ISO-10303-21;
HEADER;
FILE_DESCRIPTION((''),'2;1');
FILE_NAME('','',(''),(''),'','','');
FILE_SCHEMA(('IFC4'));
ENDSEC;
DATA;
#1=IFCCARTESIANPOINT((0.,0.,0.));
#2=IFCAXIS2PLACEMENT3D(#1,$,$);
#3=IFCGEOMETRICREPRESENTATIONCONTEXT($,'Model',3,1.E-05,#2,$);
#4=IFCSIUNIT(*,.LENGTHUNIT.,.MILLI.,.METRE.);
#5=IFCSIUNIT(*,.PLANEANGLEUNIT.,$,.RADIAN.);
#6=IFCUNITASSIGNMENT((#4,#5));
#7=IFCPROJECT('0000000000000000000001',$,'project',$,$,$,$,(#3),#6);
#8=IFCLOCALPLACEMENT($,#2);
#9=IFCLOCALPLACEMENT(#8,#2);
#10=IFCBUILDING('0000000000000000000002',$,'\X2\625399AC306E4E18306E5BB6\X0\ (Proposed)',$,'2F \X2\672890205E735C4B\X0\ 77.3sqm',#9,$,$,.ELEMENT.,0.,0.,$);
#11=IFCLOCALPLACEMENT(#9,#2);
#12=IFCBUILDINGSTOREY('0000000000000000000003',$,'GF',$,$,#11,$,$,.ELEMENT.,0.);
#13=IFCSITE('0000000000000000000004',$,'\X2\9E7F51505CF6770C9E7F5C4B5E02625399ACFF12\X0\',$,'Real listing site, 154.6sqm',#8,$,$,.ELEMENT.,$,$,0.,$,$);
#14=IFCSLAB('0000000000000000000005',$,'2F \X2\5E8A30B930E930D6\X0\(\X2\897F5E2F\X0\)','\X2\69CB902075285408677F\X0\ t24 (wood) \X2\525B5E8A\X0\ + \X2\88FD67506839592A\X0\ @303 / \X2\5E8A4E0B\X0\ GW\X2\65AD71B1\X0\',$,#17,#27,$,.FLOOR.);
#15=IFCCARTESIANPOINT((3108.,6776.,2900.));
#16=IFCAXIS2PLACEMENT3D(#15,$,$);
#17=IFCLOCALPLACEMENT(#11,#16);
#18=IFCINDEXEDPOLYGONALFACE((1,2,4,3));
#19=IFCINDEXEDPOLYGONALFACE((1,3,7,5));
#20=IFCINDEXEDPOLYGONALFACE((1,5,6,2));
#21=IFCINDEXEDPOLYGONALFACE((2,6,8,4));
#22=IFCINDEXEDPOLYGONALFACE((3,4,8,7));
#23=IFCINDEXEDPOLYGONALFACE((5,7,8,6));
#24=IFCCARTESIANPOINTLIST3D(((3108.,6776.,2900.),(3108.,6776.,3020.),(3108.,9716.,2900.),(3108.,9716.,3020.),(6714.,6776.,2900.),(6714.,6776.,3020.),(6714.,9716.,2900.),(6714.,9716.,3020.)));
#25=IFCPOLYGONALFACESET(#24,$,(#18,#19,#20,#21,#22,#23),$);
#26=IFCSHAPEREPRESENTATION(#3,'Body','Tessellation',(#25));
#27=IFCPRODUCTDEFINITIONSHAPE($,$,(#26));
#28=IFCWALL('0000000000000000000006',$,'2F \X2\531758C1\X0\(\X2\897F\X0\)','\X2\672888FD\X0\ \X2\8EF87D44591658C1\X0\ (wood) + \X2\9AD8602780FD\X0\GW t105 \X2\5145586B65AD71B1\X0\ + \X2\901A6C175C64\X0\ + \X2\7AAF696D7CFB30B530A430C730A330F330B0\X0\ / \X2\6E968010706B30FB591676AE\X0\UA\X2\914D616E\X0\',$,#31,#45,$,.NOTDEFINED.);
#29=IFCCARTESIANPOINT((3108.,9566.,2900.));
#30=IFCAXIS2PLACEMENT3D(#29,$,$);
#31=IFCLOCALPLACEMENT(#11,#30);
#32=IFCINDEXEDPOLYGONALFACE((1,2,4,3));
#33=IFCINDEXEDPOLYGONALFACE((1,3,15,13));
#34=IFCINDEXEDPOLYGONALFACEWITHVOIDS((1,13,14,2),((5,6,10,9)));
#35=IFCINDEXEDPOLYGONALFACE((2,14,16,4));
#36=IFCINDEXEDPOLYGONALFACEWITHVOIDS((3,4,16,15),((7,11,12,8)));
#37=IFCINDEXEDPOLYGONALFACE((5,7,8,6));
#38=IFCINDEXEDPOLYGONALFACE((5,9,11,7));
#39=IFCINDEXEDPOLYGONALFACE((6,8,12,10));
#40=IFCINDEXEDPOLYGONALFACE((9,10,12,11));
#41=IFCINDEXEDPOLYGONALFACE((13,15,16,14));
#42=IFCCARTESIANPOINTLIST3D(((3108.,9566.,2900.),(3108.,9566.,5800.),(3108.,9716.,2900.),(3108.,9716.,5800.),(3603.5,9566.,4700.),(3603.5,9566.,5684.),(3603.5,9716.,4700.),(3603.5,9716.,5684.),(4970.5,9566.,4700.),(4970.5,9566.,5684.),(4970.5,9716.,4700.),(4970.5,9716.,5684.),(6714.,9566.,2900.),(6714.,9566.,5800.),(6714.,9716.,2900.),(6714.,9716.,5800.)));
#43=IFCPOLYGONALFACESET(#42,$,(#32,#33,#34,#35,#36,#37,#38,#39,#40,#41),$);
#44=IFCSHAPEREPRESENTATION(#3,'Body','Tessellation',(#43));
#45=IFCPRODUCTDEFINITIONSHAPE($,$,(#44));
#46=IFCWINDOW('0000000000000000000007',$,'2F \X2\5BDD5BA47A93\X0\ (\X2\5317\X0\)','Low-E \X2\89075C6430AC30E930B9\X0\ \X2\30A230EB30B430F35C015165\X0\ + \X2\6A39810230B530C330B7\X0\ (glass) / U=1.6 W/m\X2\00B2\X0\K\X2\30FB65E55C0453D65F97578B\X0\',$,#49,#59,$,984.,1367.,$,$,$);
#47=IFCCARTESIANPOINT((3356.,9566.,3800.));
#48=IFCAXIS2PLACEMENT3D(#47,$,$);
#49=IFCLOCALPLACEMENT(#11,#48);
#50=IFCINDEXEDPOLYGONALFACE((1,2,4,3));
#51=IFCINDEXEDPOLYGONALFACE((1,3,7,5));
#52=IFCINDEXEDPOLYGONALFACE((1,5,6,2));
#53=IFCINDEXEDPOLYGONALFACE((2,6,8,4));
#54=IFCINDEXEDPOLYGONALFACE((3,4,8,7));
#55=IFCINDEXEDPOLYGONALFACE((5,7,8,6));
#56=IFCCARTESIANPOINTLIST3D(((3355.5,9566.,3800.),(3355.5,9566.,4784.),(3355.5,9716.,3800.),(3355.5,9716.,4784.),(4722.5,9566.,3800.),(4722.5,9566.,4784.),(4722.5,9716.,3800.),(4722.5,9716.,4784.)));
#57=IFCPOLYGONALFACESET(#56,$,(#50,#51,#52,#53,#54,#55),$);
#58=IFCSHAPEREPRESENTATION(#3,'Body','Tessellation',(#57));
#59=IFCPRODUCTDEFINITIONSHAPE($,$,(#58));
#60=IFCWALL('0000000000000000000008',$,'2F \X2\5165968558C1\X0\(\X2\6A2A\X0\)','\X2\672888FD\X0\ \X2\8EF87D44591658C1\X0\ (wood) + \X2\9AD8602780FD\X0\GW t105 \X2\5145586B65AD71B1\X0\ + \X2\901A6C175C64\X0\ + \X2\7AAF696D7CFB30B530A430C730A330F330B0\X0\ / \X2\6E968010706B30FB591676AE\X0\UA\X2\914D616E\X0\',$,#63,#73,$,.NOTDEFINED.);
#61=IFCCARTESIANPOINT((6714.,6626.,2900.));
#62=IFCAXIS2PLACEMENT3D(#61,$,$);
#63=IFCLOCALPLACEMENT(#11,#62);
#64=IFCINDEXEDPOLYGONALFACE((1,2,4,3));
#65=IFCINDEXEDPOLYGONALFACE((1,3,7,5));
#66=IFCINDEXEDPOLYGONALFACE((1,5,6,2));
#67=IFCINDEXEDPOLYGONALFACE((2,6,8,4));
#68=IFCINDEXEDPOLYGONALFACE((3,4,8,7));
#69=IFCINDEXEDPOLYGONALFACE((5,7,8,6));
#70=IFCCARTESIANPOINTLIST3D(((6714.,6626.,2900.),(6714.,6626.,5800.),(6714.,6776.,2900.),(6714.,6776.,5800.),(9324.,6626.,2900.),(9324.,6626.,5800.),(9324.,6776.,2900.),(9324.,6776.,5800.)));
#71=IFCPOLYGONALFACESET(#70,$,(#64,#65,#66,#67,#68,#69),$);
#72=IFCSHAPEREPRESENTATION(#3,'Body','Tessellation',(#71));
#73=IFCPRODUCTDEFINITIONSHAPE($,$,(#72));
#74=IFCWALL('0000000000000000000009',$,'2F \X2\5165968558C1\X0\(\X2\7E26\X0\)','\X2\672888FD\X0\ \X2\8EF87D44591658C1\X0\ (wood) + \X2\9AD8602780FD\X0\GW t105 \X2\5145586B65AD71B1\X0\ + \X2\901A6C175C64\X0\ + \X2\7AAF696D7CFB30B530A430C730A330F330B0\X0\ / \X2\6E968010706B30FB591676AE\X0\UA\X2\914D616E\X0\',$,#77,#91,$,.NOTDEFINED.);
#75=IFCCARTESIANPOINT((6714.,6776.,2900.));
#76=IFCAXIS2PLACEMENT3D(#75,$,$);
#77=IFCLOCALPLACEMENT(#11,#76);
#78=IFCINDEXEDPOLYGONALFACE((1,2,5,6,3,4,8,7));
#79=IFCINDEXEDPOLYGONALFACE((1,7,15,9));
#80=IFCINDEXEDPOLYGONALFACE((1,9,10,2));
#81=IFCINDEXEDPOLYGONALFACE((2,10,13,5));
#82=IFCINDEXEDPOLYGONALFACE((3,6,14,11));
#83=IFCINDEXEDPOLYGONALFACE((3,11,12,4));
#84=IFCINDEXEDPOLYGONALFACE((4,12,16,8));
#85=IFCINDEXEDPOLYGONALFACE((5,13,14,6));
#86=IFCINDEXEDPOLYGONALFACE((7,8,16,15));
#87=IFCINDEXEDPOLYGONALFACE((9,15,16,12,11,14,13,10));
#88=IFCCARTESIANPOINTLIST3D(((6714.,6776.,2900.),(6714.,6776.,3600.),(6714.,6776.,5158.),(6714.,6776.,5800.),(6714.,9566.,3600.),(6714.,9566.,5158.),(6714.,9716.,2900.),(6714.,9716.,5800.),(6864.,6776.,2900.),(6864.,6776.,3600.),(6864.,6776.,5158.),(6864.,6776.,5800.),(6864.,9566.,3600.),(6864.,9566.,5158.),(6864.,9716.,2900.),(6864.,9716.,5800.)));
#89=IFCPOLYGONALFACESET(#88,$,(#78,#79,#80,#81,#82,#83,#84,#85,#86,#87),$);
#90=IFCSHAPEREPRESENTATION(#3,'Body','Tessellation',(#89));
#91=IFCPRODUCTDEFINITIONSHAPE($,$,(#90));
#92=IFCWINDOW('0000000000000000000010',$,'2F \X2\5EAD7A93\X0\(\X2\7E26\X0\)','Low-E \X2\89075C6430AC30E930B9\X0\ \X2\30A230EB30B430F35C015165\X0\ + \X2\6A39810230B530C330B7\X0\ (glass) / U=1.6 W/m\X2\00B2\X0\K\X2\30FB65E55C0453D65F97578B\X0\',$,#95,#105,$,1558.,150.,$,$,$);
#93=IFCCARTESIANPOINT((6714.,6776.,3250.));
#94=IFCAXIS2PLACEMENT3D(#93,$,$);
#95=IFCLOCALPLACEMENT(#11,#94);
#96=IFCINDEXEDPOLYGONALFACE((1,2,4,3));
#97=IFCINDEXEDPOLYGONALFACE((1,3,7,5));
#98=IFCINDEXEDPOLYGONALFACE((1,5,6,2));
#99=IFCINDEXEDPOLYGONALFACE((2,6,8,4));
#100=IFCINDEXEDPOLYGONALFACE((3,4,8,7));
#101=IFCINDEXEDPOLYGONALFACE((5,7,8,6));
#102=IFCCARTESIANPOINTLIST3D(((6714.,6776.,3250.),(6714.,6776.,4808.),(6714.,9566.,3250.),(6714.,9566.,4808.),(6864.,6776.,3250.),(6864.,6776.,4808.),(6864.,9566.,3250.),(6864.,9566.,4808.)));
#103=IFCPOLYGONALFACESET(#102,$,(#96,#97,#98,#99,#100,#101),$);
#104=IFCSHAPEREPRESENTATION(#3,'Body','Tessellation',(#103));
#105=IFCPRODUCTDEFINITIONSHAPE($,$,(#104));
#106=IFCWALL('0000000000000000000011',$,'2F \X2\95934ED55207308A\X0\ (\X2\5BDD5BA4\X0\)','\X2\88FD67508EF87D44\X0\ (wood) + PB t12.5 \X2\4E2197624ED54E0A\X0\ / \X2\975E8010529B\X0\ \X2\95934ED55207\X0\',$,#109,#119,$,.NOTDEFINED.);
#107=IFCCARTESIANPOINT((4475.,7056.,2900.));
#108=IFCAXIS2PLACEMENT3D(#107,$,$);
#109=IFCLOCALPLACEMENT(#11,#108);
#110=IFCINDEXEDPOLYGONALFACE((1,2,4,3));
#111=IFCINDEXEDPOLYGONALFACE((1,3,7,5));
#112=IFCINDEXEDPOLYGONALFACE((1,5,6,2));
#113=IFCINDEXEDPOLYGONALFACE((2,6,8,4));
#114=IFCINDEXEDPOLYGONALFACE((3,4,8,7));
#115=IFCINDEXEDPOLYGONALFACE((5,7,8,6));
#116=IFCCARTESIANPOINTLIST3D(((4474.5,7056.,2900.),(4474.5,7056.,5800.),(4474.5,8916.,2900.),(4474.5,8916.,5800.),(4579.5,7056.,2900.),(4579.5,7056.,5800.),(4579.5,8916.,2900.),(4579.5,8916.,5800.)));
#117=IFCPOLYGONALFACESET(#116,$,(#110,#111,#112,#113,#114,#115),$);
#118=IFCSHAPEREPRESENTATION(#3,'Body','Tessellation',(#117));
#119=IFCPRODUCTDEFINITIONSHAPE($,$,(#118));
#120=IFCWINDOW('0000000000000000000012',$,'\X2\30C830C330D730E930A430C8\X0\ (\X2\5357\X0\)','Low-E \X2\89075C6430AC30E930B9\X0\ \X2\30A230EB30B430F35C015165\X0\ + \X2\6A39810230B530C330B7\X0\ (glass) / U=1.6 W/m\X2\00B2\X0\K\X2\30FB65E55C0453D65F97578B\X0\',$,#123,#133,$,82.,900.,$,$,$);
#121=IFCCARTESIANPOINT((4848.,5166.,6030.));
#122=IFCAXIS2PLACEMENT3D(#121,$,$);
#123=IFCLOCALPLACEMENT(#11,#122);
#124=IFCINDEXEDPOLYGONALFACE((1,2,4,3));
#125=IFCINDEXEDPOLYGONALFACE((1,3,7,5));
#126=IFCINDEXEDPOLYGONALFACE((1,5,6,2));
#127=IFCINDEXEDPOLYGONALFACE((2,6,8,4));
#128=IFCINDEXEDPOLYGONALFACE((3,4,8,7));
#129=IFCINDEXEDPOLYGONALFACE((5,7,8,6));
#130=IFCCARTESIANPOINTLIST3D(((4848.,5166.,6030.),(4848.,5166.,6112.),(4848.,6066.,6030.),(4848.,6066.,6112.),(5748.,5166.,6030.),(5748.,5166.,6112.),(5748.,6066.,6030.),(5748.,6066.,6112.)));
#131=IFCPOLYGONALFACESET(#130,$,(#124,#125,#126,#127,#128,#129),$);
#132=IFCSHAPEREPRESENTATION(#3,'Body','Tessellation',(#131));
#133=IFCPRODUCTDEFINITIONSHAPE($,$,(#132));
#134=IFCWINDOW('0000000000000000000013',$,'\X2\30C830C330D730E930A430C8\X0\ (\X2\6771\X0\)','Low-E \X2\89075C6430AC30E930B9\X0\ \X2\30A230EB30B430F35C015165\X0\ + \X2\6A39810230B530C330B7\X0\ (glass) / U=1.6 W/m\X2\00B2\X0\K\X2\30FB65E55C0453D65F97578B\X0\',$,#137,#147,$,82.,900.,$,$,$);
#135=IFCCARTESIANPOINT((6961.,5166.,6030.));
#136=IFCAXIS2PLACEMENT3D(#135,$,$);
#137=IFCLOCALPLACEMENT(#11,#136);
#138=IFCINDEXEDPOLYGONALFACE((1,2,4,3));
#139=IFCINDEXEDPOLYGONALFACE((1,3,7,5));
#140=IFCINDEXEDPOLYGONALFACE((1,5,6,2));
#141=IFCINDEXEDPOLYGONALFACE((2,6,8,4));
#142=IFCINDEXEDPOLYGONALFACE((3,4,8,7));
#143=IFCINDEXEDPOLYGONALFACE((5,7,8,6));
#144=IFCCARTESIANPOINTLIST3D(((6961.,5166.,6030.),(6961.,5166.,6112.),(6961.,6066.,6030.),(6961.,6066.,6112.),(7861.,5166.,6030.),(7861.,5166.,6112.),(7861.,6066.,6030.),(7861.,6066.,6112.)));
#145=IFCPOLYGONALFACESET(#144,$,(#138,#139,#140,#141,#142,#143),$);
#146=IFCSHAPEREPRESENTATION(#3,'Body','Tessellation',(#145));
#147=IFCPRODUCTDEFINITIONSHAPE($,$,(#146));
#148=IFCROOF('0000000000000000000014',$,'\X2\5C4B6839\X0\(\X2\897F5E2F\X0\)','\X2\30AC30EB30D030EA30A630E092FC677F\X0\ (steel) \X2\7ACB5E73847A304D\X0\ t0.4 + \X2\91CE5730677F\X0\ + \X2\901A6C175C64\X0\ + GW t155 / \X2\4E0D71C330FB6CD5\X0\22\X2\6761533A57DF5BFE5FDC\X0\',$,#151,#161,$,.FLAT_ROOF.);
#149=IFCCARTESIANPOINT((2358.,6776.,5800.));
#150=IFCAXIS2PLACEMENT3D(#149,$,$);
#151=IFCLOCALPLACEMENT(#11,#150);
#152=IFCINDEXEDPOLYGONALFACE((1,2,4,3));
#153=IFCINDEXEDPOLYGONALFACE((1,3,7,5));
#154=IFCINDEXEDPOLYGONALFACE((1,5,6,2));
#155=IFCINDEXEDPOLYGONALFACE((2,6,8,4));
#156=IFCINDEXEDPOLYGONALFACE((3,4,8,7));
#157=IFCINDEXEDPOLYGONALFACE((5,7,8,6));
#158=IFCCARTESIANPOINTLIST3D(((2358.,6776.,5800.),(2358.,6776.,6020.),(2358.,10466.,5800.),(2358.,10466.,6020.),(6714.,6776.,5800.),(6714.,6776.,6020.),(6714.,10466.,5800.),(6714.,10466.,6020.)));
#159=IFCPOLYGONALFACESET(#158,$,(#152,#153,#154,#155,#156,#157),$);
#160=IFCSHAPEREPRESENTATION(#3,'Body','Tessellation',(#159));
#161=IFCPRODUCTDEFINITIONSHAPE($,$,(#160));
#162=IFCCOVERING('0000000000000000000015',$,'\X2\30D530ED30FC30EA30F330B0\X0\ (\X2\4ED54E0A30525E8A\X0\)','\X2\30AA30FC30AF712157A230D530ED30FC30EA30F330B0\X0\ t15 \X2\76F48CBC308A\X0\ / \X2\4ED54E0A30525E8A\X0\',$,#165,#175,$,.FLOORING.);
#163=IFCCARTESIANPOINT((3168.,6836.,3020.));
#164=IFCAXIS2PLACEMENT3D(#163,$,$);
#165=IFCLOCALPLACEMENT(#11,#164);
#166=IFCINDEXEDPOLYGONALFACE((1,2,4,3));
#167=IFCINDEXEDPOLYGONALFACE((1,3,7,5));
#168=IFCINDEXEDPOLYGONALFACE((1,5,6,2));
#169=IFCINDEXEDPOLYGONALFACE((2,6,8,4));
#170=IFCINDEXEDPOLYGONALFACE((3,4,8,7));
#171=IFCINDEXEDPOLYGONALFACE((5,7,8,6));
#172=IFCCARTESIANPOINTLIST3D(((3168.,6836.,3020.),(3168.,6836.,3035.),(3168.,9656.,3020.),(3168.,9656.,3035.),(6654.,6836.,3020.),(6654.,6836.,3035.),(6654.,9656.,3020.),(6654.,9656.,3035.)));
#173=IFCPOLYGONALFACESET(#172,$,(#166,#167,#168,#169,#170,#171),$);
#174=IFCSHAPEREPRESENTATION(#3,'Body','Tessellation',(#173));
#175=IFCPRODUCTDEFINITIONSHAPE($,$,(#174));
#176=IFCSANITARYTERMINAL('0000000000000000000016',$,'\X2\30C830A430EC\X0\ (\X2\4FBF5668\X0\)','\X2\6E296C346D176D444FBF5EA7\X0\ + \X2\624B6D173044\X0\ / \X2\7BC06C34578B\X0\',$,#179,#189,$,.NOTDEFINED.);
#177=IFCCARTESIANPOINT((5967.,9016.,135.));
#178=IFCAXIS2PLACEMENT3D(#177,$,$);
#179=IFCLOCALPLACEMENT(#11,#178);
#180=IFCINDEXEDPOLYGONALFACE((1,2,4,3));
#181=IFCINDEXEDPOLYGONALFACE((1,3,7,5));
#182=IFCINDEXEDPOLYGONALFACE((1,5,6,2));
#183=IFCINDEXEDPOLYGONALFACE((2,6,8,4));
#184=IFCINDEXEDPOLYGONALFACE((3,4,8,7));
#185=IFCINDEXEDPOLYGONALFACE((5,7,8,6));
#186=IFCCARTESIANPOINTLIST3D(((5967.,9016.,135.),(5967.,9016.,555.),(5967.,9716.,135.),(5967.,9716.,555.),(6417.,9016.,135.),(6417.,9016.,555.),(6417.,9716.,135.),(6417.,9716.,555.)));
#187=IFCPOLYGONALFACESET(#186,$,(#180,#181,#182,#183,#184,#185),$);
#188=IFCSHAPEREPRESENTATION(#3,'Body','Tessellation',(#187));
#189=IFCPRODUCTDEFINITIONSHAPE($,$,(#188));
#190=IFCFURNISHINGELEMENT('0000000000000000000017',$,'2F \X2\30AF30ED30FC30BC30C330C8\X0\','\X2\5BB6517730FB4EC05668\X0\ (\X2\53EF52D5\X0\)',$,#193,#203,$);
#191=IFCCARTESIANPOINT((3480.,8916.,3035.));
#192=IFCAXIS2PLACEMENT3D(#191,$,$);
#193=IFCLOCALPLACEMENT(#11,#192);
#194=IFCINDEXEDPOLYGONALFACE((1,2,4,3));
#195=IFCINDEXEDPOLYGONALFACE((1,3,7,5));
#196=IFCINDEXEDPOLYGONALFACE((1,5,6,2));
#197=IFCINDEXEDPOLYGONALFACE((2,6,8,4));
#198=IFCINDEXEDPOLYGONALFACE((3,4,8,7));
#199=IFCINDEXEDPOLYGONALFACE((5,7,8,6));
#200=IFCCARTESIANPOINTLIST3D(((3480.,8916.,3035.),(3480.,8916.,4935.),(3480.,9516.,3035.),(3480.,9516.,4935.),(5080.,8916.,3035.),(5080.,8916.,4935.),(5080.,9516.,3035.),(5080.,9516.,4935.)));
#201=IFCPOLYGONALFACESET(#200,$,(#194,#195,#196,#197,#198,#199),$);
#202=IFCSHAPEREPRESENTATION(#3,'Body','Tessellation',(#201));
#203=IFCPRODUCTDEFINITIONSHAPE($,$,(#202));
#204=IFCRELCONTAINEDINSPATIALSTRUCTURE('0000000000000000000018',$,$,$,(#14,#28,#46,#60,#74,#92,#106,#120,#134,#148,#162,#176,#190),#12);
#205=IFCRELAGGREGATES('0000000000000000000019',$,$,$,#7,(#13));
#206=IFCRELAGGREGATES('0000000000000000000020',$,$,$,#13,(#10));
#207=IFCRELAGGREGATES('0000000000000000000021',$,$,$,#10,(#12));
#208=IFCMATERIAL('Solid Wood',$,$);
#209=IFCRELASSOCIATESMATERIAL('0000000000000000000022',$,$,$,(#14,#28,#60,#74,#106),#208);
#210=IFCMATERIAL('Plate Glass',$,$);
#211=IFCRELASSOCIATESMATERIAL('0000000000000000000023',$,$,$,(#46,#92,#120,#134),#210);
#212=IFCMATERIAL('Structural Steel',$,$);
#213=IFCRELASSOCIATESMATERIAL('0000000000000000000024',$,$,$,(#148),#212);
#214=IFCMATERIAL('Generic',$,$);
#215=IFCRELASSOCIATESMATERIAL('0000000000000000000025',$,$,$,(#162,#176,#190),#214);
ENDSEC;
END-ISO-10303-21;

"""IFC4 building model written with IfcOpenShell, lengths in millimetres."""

from ifc_helpers import new_model, si_unit, frame, frame_2d, origin, place, context, project, spatial, rectangle, extrude, material, element, fill, save


model = new_model("IFC4")

# Units and contexts
model_context = context("Model", 3, precision=1e-05, world=origin())
ifc_project = project(units=[si_unit("LENGTHUNIT", "METRE", prefix="MILLI"), si_unit("PLANEANGLEUNIT", "RADIAN")], contexts=[model_context])

# Site, building, storey
site_placement = place(None, origin())
site = spatial("IfcSite", under=ifc_project, at=site_placement, Name="鹿児島県鹿屋市打馬２", ObjectType="Real listing site, 154.6sqm", CompositionType="ELEMENT", RefElevation=0.0)
building_placement = place(site_placement, origin())
building = spatial("IfcBuilding", under=site, at=building_placement, Name="打馬の丘の家 (Proposed)", ObjectType="2F 木造平屋 77.3sqm", CompositionType="ELEMENT", ElevationOfRefHeight=0.0, ElevationOfTerrain=0.0)
storey_placement = place(building_placement, origin())
storey = spatial("IfcBuildingStorey", under=building, at=storey_placement, Name="GF", CompositionType="ELEMENT", Elevation=0.0)

# Slab
ifc_material_1 = material(Name="Solid Wood")
slab_placement = place(storey_placement, frame((3108.0, 6776.0, 2900.0)))
element("IfcSlab", 1, at=slab_placement, inside=storey, material=ifc_material_1, Name="2F 床スラブ(西帯)", Description="構造用合板 t24 (wood) 剛床 + 製材根太 @303 / 床下 GW断熱", PredefinedType="FLOOR", context=model_context, shape_type="SweptSolid", body=[
    extrude(rectangle(XDim=3606.0, YDim=2940.0, at=frame_2d((1803.0, 1470.0))), frame((3108.0, 6776.0, 2900.0)), (0.0, 0.0, 1.0), 120.0),
])

# Wall, opening, window
wall_1_placement = place(storey_placement, frame((3108.0, 9566.0, 2900.0)))
wall_1 = element("IfcWall", 2, at=wall_1_placement, inside=storey, material=ifc_material_1, Name="2F 北壁(西)", Description="木製 軸組外壁 (wood) + 高性能GW t105 充填断熱 + 通気層 + 窯業系サイディング / 準耐火・外皮UA配慮", PredefinedType="NOTDEFINED", context=model_context, shape_type="SweptSolid", body=[
    extrude(rectangle(XDim=3606.0, YDim=150.0, at=frame_2d((1803.0, 75.0))), frame((3108.0, 9566.0, 2900.0)), (0.0, 0.0, 1.0), 2900.0),
])
opening_1_placement = place(storey_placement, frame((3356.0, 9566.0, 3800.0)))
opening_1 = element("IfcOpeningElement", 3, at=opening_1_placement, cuts=wall_1, PredefinedType="NOTDEFINED", context=model_context, shape_type="SweptSolid", body=[
    extrude(rectangle(XDim=1367.0, YDim=150.0, at=frame_2d((683.0, 75.0))), frame((3356.0, 9566.0, 3800.0)), (0.0, 0.0, 1.0), 984.0),
])
ifc_material_2 = material(Name="Plate Glass")
window_1_placement = place(storey_placement, frame((3356.0, 9566.0, 3800.0)))
window_1 = element("IfcWindow", 4, at=window_1_placement, inside=storey, material=ifc_material_2, Name="2F 寝室窓 (北)", Description="Low-E 複層ガラス アルゴン封入 + 樹脂サッシ (glass) / U=1.6 W/m²K・日射取得型", OverallHeight=984.0, OverallWidth=1367.0, context=model_context, shape_type="SweptSolid", body=[
    extrude(rectangle(XDim=1367.0, YDim=150.0, at=frame_2d((683.0, 75.0))), frame((3356.0, 9566.0, 3800.0)), (0.0, 0.0, 1.0), 984.0),
])
fill(opening_1, window_1)

# Wall
wall_2_placement = place(storey_placement, frame((6714.0, 6626.0, 2900.0)))
element("IfcWall", 5, at=wall_2_placement, inside=storey, material=ifc_material_1, Name="2F 入隅壁(横)", Description="木製 軸組外壁 (wood) + 高性能GW t105 充填断熱 + 通気層 + 窯業系サイディング / 準耐火・外皮UA配慮", PredefinedType="NOTDEFINED", context=model_context, shape_type="SweptSolid", body=[
    extrude(rectangle(XDim=2610.0, YDim=150.0, at=frame_2d((1305.0, 75.0))), frame((6714.0, 6626.0, 2900.0)), (0.0, 0.0, 1.0), 2900.0),
])

# Wall, opening, window
wall_3_placement = place(storey_placement, frame((6714.0, 6776.0, 2900.0)))
wall_3 = element("IfcWall", 6, at=wall_3_placement, inside=storey, material=ifc_material_1, Name="2F 入隅壁(縦)", Description="木製 軸組外壁 (wood) + 高性能GW t105 充填断熱 + 通気層 + 窯業系サイディング / 準耐火・外皮UA配慮", PredefinedType="NOTDEFINED", context=model_context, shape_type="SweptSolid", body=[
    extrude(rectangle(XDim=150.0, YDim=2940.0, at=frame_2d((75.0, 1470.0))), frame((6714.0, 6776.0, 2900.0)), (0.0, 0.0, 1.0), 2900.0),
])
opening_2_placement = place(storey_placement, frame((6714.0, 6776.0, 3250.0)))
opening_2 = element("IfcOpeningElement", 7, at=opening_2_placement, cuts=wall_3, PredefinedType="NOTDEFINED", context=model_context, shape_type="SweptSolid", body=[
    extrude(rectangle(XDim=150.0, YDim=2790.0, at=frame_2d((75.0, 1395.0))), frame((6714.0, 6776.0, 3250.0)), (0.0, 0.0, 1.0), 1558.0),
])
window_2_placement = place(storey_placement, frame((6714.0, 6776.0, 3250.0)))
window_2 = element("IfcWindow", 8, at=window_2_placement, inside=storey, material=ifc_material_2, Name="2F 庭窓(縦)", Description="Low-E 複層ガラス アルゴン封入 + 樹脂サッシ (glass) / U=1.6 W/m²K・日射取得型", OverallHeight=1558.0, OverallWidth=150.0, context=model_context, shape_type="SweptSolid", body=[
    extrude(rectangle(XDim=150.0, YDim=2790.0, at=frame_2d((75.0, 1395.0))), frame((6714.0, 6776.0, 3250.0)), (0.0, 0.0, 1.0), 1558.0),
])
fill(opening_2, window_2)

# Wall
wall_4_placement = place(storey_placement, frame((4475.0, 7056.0, 2900.0)))
element("IfcWall", 9, at=wall_4_placement, inside=storey, material=ifc_material_1, Name="2F 間仕切り (寝室)", Description="製材軸組 (wood) + PB t12.5 両面仕上 / 非耐力 間仕切", PredefinedType="NOTDEFINED", context=model_context, shape_type="SweptSolid", body=[
    extrude(rectangle(XDim=105.0, YDim=1860.0, at=frame_2d((52.0, 930.0))), frame((4475.0, 7056.0, 2900.0)), (0.0, 0.0, 1.0), 2900.0),
])

# Windows
window_3_placement = place(storey_placement, frame((4848.0, 5166.0, 6030.0)))
element("IfcWindow", 10, at=window_3_placement, inside=storey, material=ifc_material_2, Name="トップライト (南)", Description="Low-E 複層ガラス アルゴン封入 + 樹脂サッシ (glass) / U=1.6 W/m²K・日射取得型", OverallHeight=82.0, OverallWidth=900.0, context=model_context, shape_type="SweptSolid", body=[
    extrude(rectangle(XDim=900.0, YDim=900.0, at=frame_2d((450.0, 450.0))), frame((4848.0, 5166.0, 6030.0)), (0.0, 0.0, 1.0), 82.0),
])
window_4_placement = place(storey_placement, frame((6961.0, 5166.0, 6030.0)))
element("IfcWindow", 11, at=window_4_placement, inside=storey, material=ifc_material_2, Name="トップライト (東)", Description="Low-E 複層ガラス アルゴン封入 + 樹脂サッシ (glass) / U=1.6 W/m²K・日射取得型", OverallHeight=82.0, OverallWidth=900.0, context=model_context, shape_type="SweptSolid", body=[
    extrude(rectangle(XDim=900.0, YDim=900.0, at=frame_2d((450.0, 450.0))), frame((6961.0, 5166.0, 6030.0)), (0.0, 0.0, 1.0), 82.0),
])

# Roof
ifc_material_3 = material(Name="Structural Steel")
for number, where, name in (
    (12, (2358.0, 6776.0, 5800.0), "屋根(西帯)"),
):
    element("IfcRoof", number, at=place(storey_placement, frame(where)), inside=storey, material=ifc_material_3, Name=name, Description="ガルバリウム鋼板 (steel) 立平葺き t0.4 + 野地板 + 通気層 + GW t155 / 不燃・法22条区域対応", PredefinedType="FLAT_ROOF", context=model_context, shape_type="SweptSolid", body=[
        extrude(rectangle(XDim=4356.0, YDim=3690.0, at=frame_2d((2178.0, 1845.0))), frame((2358.0, 6776.0, 5800.0)), (0.0, 0.0, 1.0), 220.0),
    ])

# Covering
ifc_material_4 = material(Name="Generic")
covering_placement = place(storey_placement, frame((3168.0, 6836.0, 3020.0)))
element("IfcCovering", 13, at=covering_placement, inside=storey, material=ifc_material_4, Name="フローリング (仕上げ床)", Description="オーク無垢フローリング t15 直貼り / 仕上げ床", PredefinedType="FLOORING", context=model_context, shape_type="SweptSolid", body=[
    extrude(rectangle(XDim=3486.0, YDim=2820.0, at=frame_2d((1743.0, 1410.0))), frame((3168.0, 6836.0, 3020.0)), (0.0, 0.0, 1.0), 15.0),
])

# Sanitary terminal
sanitary_terminal_placement = place(storey_placement, frame((5967.0, 9016.0, 135.0)))
element("IfcSanitaryTerminal", 14, at=sanitary_terminal_placement, inside=storey, material=ifc_material_4, Name="トイレ (便器)", Description="温水洗浄便座 + 手洗い / 節水型", PredefinedType="NOTDEFINED", context=model_context, shape_type="SweptSolid", body=[
    extrude(rectangle(XDim=450.0, YDim=700.0, at=frame_2d((225.0, 350.0))), frame((5967.0, 9016.0, 135.0)), (0.0, 0.0, 1.0), 420.0),
])

# Furnishing element
furnishing_1_placement = place(storey_placement, frame((3480.0, 8916.0, 3035.0)))
element("IfcFurnishingElement", 15, at=furnishing_1_placement, inside=storey, material=ifc_material_4, Name="2F クローゼット", Description="家具・什器 (可動)", context=model_context, shape_type="SweptSolid", body=[
    extrude(rectangle(XDim=1600.0, YDim=600.0, at=frame_2d((800.0, 300.0))), frame((3480.0, 8916.0, 3035.0)), (0.0, 0.0, 1.0), 1900.0),
])

save(model, "model.ifc")
